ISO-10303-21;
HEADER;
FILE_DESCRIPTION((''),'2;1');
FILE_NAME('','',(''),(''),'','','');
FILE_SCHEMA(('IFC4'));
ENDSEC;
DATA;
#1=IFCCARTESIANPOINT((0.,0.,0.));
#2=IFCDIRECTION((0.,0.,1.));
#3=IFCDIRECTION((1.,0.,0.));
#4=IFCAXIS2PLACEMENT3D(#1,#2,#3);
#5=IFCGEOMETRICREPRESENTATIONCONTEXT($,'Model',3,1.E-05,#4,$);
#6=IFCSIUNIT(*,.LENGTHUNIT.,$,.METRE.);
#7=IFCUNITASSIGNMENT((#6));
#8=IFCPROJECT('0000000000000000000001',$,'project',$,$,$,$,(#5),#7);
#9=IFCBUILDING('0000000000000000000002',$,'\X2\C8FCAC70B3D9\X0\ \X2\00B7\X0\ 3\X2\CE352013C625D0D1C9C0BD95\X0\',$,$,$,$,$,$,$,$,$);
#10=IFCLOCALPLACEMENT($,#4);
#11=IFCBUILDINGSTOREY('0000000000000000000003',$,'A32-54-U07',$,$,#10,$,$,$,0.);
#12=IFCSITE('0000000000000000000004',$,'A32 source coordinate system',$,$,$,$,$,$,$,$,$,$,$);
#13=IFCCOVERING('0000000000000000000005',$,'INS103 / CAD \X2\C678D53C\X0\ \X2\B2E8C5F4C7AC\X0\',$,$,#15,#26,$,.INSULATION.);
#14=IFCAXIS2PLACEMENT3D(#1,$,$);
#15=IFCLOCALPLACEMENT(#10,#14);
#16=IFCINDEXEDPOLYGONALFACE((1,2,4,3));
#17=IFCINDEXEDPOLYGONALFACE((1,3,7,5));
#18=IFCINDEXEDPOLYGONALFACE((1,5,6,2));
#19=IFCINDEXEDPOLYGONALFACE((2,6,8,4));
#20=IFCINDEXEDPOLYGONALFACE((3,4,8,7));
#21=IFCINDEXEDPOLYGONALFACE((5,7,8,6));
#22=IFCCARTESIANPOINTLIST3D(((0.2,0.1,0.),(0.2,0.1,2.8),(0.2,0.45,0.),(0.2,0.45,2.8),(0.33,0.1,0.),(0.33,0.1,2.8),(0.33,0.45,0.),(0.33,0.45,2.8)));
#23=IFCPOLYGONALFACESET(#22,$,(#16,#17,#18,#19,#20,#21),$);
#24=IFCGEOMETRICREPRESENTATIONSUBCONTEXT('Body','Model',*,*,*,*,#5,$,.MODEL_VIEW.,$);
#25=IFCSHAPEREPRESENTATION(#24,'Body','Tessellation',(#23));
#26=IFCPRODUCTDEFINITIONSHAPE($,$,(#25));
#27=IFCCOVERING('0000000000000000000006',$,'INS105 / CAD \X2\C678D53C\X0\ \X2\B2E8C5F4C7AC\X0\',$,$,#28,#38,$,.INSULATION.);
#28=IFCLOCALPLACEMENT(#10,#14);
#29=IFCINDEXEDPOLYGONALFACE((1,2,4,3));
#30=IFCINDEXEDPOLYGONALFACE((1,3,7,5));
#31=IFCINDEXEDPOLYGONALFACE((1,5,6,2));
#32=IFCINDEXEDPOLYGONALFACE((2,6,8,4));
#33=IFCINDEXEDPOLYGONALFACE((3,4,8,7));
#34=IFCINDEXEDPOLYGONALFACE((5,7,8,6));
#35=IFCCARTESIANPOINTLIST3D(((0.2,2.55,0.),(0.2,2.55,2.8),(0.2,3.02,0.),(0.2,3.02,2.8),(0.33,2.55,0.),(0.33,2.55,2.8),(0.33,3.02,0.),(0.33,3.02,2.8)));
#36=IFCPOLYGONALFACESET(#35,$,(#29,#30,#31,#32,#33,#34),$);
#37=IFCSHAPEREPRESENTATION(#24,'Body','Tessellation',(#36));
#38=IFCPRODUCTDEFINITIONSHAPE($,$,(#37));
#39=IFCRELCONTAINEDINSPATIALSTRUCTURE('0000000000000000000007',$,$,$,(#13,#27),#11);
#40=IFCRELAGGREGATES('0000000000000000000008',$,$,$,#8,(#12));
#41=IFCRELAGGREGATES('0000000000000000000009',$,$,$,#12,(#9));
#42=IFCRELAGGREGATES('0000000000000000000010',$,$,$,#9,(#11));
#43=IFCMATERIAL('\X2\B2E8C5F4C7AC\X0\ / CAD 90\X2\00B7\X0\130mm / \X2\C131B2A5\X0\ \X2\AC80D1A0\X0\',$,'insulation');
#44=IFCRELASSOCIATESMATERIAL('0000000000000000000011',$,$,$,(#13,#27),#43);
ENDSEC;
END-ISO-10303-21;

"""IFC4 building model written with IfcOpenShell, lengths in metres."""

from ifc_helpers import new_model, si_unit, origin, origin_with_axes, place, context, subcontext, project, spatial, polyline, outline, extrude, material, element, save


model = new_model("IFC4")

# Units and contexts
model_context = context("Model", 3, precision=1e-05, world=origin_with_axes())
body_context = subcontext(model_context, "Body", "Model", "MODEL_VIEW")
ifc_project = project(units=[si_unit("LENGTHUNIT", "METRE")], contexts=[model_context])

# Site, building, storey
storey_placement = place(None, origin_with_axes())
site = spatial("IfcSite", under=ifc_project, Name="A32 source coordinate system")
building = spatial("IfcBuilding", under=site, Name="주거동 · 3층–옥탑지붕")
storey = spatial("IfcBuildingStorey", under=building, at=storey_placement, Name="A32-54-U07", Elevation=0.0)

# Coverings
ifc_material = material(Name="단열재 / CAD 90·130mm / 성능 검토", Category="insulation")
covering_1_placement = place(storey_placement, origin_with_axes())
element("IfcCovering", 1, at=covering_1_placement, inside=storey, material=ifc_material, Name="INS103 / CAD 외피 단열재", PredefinedType="INSULATION", context=body_context, shape_type="SweptSolid", body=[
    extrude(outline(polyline([(0.2, 0.45), (0.33, 0.45), (0.33, 0.1), (0.2, 0.1), (0.2, 0.45)])), origin(), (0.0, 0.0, 1.0), 2.8),
])
covering_2_placement = place(storey_placement, origin_with_axes())
element("IfcCovering", 2, at=covering_2_placement, inside=storey, material=ifc_material, Name="INS105 / CAD 외피 단열재", PredefinedType="INSULATION", context=body_context, shape_type="SweptSolid", body=[
    extrude(outline(polyline([(0.2, 3.02), (0.33, 3.02), (0.33, 2.55), (0.2, 2.55), (0.2, 3.02)])), origin(), (0.0, 0.0, 1.0), 2.8),
])

save(model, "model.ifc")
